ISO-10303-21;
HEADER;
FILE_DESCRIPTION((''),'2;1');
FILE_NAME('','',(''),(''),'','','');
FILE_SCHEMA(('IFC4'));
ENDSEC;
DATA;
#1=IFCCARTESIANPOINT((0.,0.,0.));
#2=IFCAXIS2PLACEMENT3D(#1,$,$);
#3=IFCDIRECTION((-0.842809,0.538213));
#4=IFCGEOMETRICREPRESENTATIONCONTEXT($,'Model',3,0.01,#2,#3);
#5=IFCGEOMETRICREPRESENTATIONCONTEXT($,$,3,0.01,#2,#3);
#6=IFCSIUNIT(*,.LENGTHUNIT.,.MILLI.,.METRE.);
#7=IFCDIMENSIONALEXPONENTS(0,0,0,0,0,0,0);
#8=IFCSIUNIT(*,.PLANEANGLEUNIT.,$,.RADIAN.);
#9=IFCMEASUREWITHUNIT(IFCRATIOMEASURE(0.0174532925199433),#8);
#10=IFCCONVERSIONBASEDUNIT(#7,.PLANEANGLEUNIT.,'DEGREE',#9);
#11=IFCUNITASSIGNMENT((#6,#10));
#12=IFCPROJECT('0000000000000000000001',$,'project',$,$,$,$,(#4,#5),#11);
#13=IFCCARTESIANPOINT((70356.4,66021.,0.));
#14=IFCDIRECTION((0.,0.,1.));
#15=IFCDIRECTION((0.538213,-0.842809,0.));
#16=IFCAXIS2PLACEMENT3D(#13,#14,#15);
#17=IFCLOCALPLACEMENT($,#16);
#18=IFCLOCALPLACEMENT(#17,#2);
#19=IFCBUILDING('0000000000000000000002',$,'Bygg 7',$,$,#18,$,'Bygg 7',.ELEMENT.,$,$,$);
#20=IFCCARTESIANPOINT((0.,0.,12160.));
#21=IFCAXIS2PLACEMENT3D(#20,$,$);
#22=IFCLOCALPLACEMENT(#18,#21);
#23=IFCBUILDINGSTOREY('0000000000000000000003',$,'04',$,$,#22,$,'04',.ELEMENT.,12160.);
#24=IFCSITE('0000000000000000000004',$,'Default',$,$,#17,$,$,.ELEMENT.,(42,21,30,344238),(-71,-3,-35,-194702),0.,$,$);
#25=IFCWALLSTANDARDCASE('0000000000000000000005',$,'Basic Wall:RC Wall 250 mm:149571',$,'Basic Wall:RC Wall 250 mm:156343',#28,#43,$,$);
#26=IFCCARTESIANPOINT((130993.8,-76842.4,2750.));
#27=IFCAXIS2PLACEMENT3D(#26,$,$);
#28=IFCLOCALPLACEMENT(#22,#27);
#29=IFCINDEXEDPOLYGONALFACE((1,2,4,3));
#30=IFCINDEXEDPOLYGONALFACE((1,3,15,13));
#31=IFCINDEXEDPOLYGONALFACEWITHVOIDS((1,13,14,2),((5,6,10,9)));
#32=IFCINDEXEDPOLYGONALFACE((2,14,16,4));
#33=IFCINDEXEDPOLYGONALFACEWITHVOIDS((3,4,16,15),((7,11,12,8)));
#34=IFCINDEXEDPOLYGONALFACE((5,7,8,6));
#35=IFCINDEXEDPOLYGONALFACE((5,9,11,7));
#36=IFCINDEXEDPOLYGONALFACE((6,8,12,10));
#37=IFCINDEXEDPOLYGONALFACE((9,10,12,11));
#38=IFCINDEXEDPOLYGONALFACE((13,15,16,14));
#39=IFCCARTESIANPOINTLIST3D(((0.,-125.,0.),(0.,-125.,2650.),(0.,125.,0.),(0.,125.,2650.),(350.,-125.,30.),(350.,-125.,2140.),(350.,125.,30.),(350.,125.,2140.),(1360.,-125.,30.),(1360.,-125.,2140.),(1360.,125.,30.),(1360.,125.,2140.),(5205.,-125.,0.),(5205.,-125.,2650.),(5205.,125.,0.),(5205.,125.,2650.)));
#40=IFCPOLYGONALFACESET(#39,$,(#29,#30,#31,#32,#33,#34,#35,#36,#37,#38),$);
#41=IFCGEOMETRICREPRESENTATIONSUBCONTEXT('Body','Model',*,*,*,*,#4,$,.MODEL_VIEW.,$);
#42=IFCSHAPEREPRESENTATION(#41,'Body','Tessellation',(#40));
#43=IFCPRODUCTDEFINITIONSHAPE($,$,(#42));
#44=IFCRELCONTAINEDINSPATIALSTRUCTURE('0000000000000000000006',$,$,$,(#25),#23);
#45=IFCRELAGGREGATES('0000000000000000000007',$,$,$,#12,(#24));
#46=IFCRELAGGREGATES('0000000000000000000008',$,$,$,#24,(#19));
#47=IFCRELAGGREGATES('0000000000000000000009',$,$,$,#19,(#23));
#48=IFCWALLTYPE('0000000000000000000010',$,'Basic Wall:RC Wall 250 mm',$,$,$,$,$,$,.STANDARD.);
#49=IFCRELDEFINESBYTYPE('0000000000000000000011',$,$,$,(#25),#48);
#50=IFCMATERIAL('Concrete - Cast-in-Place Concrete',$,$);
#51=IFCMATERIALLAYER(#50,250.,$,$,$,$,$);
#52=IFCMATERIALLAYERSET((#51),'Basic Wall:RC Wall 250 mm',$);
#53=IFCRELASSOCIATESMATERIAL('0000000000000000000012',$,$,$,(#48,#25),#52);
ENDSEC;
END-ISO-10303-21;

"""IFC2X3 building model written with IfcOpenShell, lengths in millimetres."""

from ifc_helpers import new_model, entity, si_unit, converted_unit, direction, frame, frame_2d, origin, origin_2d_with_axis, place, context, subcontext, project, spatial, polyline, rectangle, extrude, clip, bounded_halfspace, material, layer, layer_set, layer_usage, type_object, element, save


model = new_model("IFC2X3")

# Units and contexts
model_context = context("Model", 3, precision=0.01, world=origin(), true_north=direction((-0.842809, 0.538213)))
context_of_model = context(None, 3, precision=0.01, world=origin(), true_north=direction((-0.842809, 0.538213)))
body_context = subcontext(model_context, "Body", "Model", "MODEL_VIEW")
ifc_project = project(units=[si_unit("LENGTHUNIT", "METRE", prefix="MILLI"), converted_unit("PLANEANGLEUNIT", "DEGREE", entity("IfcRatioMeasure", 0.0174532925199433), si_unit("PLANEANGLEUNIT", "RADIAN"), dimensions=[0, 0, 0, 0, 0, 0, 0])], contexts=[model_context, context_of_model])

# Site, building, storey
site_placement = place(None, frame((70356.4, 66021.0, 0.0), z_axis=(0.0, 0.0, 1.0), x_axis=(0.538213, -0.842809, 0.0)))
site = spatial("IfcSite", under=ifc_project, at=site_placement, Name="Default", CompositionType="ELEMENT", RefLatitude=(42, 21, 30, 344238), RefLongitude=(-71, -3, -35, -194702), RefElevation=0.0)
building_placement = place(site_placement, origin())
building = spatial("IfcBuilding", under=site, at=building_placement, Name="Bygg 7", LongName="Bygg 7", CompositionType="ELEMENT")
storey_placement = place(building_placement, frame((0.0, 0.0, 12160.0)))
storey = spatial("IfcBuildingStorey", under=building, at=storey_placement, Name="04", LongName="04", CompositionType="ELEMENT", Elevation=12160.0)

# Shared definitions
ifc_material_1 = material(Name="Concrete - Cast-in-Place Concrete")

# Wall, opening
ifc_layer_1 = layer(ifc_material_1, 250.0)
ifc_layer_set_1 = layer_set([ifc_layer_1], Name="Basic Wall:RC Wall 250 mm")
ifc_layer_usage_1 = layer_usage(ifc_layer_set_1, "AXIS2", "NEGATIVE", 125.0)
wall_type_1 = type_object("IfcWallType", Name="Basic Wall:RC Wall 250 mm", PredefinedType="STANDARD", material=ifc_layer_set_1)
wall_1_placement = place(storey_placement, frame((130993.8, -76842.4, 2750.0)))
wall_1 = element("IfcWallStandardCase", 1, at=wall_1_placement, inside=storey, type_object=wall_type_1, material=ifc_layer_usage_1, Name="Basic Wall:RC Wall 250 mm:149571", ObjectType="Basic Wall:RC Wall 250 mm:156343", context=body_context, shape_type="Clipping", body=[
    clip(clip(clip(extrude(rectangle(XDim=5205.0, YDim=250.0, at=frame_2d((2602.5, 0.0), x_axis=(-1.0, 0.0))), origin(), (0.0, 0.0, 1.0), 2650.0), bounded_halfspace(frame((0.0, -125.0, 2650.0), z_axis=(0.0, 0.0, -1.0), x_axis=(0.092529, -0.99571, 0.0)), True, frame((0.0, -125.0, 2650.0)), polyline([(0.0, 0.0), (220.0, 0.0), (2231.0, 0.0), (4985.0, 0.0), (5205.0, 0.0), (5205.0, 250.0), (4955.0, 250.0), (250.0, 250.0), (0.0, 250.0), (0.0, 0.0)]))), bounded_halfspace(frame((5205.0, 125.0, 0.0), z_axis=(0.0, 0.0, 1.0), x_axis=(-0.092529, 0.99571, 0.0)), True, frame((5205.0, 125.0, 0.0)), polyline([(0.0, 0.0), (-250.0, 0.0), (-3845.0, 0.0), (-3845.0, -250.0), (-2974.0, -250.0), (-220.0, -250.0), (0.0, -250.0), (0.0, 0.0)]))), bounded_halfspace(frame((0.0, -125.0, 0.0), z_axis=(0.0, 0.0, 1.0), x_axis=(-0.092529, 0.99571, 0.0)), True, frame((0.0, -125.0, 0.0)), polyline([(0.0, 0.0), (220.0, 0.0), (350.0, 0.0), (350.0, 250.0), (250.0, 250.0), (0.0, 250.0), (0.0, 0.0)]))),
])
opening_1_placement = place(wall_1_placement, origin())
element("IfcOpeningElement", 2, at=opening_1_placement, cuts=wall_1, ObjectType="Opening", context=body_context, shape_type="SweptSolid", body=[
    extrude(rectangle(XDim=2110.0, YDim=1010.0, at=origin_2d_with_axis()), frame((855.0, -125.0, 1085.0), z_axis=(0.0, 1.0, 0.0), x_axis=(0.0, 0.0, -1.0)), (0.0, 0.0, 1.0), 250.0),
])

save(model, "model.ifc")
